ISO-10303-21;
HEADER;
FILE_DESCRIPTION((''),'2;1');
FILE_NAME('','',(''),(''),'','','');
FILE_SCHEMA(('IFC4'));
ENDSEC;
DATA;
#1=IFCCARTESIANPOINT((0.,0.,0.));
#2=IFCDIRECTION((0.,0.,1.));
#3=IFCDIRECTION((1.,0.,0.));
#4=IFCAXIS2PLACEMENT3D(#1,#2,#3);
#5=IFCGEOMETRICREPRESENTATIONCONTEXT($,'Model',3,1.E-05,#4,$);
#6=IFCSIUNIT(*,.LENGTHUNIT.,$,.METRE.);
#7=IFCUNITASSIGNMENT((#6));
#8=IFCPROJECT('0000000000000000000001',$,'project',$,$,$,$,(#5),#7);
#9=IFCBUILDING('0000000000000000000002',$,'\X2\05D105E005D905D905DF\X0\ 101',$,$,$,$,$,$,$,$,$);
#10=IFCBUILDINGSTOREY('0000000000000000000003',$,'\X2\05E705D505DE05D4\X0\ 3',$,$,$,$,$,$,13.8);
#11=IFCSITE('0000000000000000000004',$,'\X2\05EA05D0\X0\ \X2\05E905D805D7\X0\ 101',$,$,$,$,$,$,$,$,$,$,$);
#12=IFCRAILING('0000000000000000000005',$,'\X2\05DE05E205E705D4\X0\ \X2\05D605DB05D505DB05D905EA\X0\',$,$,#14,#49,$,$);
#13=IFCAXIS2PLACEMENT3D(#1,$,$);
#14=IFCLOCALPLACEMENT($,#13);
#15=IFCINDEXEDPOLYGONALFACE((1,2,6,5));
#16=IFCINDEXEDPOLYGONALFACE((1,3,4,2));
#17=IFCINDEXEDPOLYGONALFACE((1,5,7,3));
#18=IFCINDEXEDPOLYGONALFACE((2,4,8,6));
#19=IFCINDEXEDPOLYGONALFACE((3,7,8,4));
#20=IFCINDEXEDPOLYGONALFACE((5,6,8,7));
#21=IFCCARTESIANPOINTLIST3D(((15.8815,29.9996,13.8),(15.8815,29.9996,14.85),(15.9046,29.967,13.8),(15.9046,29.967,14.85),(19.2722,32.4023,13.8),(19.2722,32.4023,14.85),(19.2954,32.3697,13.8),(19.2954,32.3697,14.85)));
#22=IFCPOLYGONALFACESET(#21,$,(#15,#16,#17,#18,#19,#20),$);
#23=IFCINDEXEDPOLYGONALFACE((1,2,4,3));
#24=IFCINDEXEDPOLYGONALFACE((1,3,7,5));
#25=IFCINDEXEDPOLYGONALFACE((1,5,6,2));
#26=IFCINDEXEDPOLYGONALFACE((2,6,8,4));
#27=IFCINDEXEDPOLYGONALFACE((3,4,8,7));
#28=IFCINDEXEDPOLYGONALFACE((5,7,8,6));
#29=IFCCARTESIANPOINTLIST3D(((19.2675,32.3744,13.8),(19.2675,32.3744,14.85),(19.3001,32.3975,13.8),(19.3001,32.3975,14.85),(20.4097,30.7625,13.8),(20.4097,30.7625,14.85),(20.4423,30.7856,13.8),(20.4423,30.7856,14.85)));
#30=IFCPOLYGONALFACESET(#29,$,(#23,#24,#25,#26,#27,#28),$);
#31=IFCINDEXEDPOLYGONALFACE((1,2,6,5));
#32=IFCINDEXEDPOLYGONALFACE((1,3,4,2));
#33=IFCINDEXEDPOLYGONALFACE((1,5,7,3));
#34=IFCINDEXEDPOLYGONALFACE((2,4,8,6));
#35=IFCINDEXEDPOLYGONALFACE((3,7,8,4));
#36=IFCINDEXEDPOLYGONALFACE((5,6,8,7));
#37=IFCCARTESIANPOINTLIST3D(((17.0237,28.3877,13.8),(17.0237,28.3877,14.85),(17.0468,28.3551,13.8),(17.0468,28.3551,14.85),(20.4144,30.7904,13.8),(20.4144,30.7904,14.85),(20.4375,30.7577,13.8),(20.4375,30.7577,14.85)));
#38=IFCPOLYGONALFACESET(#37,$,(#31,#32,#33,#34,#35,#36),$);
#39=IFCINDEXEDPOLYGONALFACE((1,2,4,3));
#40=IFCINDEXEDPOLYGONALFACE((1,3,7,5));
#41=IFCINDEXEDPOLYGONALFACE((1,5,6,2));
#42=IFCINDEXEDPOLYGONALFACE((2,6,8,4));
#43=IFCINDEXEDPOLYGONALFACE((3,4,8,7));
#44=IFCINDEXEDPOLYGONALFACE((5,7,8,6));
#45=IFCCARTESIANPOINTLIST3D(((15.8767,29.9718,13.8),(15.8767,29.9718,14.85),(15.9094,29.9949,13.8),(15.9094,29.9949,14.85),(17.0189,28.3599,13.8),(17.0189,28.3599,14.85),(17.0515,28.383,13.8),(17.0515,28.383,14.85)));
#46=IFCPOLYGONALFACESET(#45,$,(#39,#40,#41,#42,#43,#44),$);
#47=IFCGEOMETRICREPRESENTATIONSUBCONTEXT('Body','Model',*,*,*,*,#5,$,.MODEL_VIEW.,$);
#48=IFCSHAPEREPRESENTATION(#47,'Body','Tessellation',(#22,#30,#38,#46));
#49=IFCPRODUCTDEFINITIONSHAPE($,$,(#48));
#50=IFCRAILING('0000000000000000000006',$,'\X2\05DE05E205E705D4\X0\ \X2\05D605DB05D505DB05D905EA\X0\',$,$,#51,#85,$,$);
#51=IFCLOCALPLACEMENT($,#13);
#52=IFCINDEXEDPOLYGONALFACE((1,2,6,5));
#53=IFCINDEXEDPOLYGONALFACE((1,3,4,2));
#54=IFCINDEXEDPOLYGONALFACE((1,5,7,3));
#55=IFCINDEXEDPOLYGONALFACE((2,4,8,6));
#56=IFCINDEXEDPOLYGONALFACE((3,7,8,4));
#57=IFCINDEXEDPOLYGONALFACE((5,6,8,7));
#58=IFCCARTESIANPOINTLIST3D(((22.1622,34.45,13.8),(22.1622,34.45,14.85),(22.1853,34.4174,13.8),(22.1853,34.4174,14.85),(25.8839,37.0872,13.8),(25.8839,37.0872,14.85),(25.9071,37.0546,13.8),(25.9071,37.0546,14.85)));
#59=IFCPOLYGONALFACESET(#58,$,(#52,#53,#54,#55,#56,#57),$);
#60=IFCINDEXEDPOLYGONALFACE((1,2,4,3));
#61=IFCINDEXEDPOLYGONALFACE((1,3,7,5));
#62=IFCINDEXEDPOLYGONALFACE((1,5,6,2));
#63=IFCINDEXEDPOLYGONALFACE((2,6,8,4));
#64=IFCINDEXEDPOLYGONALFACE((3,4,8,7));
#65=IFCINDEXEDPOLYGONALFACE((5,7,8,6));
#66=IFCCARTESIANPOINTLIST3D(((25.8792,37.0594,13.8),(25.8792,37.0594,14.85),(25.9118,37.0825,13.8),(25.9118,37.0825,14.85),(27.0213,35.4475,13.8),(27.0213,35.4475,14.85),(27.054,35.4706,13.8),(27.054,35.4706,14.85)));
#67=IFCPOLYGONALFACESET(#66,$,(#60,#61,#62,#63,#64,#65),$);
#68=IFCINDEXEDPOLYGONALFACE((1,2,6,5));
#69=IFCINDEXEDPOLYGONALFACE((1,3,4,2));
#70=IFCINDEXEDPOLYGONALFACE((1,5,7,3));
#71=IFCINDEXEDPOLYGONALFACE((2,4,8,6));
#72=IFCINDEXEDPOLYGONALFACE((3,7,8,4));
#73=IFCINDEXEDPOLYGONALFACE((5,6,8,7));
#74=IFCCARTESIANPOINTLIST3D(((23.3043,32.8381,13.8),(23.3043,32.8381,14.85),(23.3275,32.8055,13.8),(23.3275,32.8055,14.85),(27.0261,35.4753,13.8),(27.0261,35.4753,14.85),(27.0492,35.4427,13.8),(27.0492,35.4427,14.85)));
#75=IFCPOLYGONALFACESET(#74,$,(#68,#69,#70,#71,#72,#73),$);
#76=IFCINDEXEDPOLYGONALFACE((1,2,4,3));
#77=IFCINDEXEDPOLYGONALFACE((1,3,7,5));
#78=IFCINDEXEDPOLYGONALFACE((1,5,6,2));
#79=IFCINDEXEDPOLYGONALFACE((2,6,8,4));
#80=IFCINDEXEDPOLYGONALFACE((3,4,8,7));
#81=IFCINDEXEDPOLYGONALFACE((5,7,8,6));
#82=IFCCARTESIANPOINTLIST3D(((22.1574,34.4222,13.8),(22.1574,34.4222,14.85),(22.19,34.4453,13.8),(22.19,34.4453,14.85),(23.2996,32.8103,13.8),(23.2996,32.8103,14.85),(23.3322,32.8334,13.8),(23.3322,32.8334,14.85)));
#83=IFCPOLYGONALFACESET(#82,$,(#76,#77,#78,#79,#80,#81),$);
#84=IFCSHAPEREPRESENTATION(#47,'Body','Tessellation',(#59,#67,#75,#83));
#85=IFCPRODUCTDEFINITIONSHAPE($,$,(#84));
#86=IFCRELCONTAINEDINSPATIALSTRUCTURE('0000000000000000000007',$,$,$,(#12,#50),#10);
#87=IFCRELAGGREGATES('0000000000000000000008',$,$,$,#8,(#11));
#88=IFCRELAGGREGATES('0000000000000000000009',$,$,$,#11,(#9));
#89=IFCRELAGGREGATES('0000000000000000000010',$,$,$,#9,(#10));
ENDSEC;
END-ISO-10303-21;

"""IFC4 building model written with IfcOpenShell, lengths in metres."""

from ifc_helpers import new_model, si_unit, frame, origin_with_axes, context, subcontext, project, spatial, polyline, outline, extrude, element, save


model = new_model("IFC4")

# Units and contexts
model_context = context("Model", 3, precision=1e-05, world=origin_with_axes())
body_context = subcontext(model_context, "Body", "Model", "MODEL_VIEW")
ifc_project = project(units=[si_unit("LENGTHUNIT", "METRE")], contexts=[model_context])

# Site, building, storey
site = spatial("IfcSite", under=ifc_project, Name="תא שטח 101")
building = spatial("IfcBuilding", under=site, Name="בניין 101")
storey = spatial("IfcBuildingStorey", under=building, Name="קומה 3", Elevation=13.8)

# Railings
element("IfcRailing", 1, inside=storey, Name="מעקה זכוכית", context=body_context, shape_type="SweptSolid", body=[
    extrude(outline(polyline([(15.9046, 29.967), (19.2954, 32.3697), (19.2722, 32.4023), (15.8815, 29.9996), (15.9046, 29.967)])), frame((0.0, 0.0, 13.8)), (0.0, 0.0, 1.0), 1.05),
    extrude(outline(polyline([(19.2675, 32.3744), (20.4097, 30.7625), (20.4423, 30.7856), (19.3001, 32.3975), (19.2675, 32.3744)])), frame((0.0, 0.0, 13.8)), (0.0, 0.0, 1.0), 1.05),
    extrude(outline(polyline([(20.4144, 30.7904), (17.0237, 28.3877), (17.0468, 28.3551), (20.4375, 30.7577), (20.4144, 30.7904)])), frame((0.0, 0.0, 13.8)), (0.0, 0.0, 1.0), 1.05),
    extrude(outline(polyline([(17.0515, 28.383), (15.9094, 29.9949), (15.8767, 29.9718), (17.0189, 28.3599), (17.0515, 28.383)])), frame((0.0, 0.0, 13.8)), (0.0, 0.0, 1.0), 1.05),
])
element("IfcRailing", 2, inside=storey, Name="מעקה זכוכית", context=body_context, shape_type="SweptSolid", body=[
    extrude(outline(polyline([(22.1853, 34.4174), (25.9071, 37.0546), (25.8839, 37.0872), (22.1622, 34.45), (22.1853, 34.4174)])), frame((0.0, 0.0, 13.8)), (0.0, 0.0, 1.0), 1.05),
    extrude(outline(polyline([(25.8792, 37.0594), (27.0213, 35.4475), (27.054, 35.4706), (25.9118, 37.0825), (25.8792, 37.0594)])), frame((0.0, 0.0, 13.8)), (0.0, 0.0, 1.0), 1.05),
    extrude(outline(polyline([(27.0261, 35.4753), (23.3043, 32.8381), (23.3275, 32.8055), (27.0492, 35.4427), (27.0261, 35.4753)])), frame((0.0, 0.0, 13.8)), (0.0, 0.0, 1.0), 1.05),
    extrude(outline(polyline([(23.3322, 32.8334), (22.19, 34.4453), (22.1574, 34.4222), (23.2996, 32.8103), (23.3322, 32.8334)])), frame((0.0, 0.0, 13.8)), (0.0, 0.0, 1.0), 1.05),
])

save(model, "model.ifc")
